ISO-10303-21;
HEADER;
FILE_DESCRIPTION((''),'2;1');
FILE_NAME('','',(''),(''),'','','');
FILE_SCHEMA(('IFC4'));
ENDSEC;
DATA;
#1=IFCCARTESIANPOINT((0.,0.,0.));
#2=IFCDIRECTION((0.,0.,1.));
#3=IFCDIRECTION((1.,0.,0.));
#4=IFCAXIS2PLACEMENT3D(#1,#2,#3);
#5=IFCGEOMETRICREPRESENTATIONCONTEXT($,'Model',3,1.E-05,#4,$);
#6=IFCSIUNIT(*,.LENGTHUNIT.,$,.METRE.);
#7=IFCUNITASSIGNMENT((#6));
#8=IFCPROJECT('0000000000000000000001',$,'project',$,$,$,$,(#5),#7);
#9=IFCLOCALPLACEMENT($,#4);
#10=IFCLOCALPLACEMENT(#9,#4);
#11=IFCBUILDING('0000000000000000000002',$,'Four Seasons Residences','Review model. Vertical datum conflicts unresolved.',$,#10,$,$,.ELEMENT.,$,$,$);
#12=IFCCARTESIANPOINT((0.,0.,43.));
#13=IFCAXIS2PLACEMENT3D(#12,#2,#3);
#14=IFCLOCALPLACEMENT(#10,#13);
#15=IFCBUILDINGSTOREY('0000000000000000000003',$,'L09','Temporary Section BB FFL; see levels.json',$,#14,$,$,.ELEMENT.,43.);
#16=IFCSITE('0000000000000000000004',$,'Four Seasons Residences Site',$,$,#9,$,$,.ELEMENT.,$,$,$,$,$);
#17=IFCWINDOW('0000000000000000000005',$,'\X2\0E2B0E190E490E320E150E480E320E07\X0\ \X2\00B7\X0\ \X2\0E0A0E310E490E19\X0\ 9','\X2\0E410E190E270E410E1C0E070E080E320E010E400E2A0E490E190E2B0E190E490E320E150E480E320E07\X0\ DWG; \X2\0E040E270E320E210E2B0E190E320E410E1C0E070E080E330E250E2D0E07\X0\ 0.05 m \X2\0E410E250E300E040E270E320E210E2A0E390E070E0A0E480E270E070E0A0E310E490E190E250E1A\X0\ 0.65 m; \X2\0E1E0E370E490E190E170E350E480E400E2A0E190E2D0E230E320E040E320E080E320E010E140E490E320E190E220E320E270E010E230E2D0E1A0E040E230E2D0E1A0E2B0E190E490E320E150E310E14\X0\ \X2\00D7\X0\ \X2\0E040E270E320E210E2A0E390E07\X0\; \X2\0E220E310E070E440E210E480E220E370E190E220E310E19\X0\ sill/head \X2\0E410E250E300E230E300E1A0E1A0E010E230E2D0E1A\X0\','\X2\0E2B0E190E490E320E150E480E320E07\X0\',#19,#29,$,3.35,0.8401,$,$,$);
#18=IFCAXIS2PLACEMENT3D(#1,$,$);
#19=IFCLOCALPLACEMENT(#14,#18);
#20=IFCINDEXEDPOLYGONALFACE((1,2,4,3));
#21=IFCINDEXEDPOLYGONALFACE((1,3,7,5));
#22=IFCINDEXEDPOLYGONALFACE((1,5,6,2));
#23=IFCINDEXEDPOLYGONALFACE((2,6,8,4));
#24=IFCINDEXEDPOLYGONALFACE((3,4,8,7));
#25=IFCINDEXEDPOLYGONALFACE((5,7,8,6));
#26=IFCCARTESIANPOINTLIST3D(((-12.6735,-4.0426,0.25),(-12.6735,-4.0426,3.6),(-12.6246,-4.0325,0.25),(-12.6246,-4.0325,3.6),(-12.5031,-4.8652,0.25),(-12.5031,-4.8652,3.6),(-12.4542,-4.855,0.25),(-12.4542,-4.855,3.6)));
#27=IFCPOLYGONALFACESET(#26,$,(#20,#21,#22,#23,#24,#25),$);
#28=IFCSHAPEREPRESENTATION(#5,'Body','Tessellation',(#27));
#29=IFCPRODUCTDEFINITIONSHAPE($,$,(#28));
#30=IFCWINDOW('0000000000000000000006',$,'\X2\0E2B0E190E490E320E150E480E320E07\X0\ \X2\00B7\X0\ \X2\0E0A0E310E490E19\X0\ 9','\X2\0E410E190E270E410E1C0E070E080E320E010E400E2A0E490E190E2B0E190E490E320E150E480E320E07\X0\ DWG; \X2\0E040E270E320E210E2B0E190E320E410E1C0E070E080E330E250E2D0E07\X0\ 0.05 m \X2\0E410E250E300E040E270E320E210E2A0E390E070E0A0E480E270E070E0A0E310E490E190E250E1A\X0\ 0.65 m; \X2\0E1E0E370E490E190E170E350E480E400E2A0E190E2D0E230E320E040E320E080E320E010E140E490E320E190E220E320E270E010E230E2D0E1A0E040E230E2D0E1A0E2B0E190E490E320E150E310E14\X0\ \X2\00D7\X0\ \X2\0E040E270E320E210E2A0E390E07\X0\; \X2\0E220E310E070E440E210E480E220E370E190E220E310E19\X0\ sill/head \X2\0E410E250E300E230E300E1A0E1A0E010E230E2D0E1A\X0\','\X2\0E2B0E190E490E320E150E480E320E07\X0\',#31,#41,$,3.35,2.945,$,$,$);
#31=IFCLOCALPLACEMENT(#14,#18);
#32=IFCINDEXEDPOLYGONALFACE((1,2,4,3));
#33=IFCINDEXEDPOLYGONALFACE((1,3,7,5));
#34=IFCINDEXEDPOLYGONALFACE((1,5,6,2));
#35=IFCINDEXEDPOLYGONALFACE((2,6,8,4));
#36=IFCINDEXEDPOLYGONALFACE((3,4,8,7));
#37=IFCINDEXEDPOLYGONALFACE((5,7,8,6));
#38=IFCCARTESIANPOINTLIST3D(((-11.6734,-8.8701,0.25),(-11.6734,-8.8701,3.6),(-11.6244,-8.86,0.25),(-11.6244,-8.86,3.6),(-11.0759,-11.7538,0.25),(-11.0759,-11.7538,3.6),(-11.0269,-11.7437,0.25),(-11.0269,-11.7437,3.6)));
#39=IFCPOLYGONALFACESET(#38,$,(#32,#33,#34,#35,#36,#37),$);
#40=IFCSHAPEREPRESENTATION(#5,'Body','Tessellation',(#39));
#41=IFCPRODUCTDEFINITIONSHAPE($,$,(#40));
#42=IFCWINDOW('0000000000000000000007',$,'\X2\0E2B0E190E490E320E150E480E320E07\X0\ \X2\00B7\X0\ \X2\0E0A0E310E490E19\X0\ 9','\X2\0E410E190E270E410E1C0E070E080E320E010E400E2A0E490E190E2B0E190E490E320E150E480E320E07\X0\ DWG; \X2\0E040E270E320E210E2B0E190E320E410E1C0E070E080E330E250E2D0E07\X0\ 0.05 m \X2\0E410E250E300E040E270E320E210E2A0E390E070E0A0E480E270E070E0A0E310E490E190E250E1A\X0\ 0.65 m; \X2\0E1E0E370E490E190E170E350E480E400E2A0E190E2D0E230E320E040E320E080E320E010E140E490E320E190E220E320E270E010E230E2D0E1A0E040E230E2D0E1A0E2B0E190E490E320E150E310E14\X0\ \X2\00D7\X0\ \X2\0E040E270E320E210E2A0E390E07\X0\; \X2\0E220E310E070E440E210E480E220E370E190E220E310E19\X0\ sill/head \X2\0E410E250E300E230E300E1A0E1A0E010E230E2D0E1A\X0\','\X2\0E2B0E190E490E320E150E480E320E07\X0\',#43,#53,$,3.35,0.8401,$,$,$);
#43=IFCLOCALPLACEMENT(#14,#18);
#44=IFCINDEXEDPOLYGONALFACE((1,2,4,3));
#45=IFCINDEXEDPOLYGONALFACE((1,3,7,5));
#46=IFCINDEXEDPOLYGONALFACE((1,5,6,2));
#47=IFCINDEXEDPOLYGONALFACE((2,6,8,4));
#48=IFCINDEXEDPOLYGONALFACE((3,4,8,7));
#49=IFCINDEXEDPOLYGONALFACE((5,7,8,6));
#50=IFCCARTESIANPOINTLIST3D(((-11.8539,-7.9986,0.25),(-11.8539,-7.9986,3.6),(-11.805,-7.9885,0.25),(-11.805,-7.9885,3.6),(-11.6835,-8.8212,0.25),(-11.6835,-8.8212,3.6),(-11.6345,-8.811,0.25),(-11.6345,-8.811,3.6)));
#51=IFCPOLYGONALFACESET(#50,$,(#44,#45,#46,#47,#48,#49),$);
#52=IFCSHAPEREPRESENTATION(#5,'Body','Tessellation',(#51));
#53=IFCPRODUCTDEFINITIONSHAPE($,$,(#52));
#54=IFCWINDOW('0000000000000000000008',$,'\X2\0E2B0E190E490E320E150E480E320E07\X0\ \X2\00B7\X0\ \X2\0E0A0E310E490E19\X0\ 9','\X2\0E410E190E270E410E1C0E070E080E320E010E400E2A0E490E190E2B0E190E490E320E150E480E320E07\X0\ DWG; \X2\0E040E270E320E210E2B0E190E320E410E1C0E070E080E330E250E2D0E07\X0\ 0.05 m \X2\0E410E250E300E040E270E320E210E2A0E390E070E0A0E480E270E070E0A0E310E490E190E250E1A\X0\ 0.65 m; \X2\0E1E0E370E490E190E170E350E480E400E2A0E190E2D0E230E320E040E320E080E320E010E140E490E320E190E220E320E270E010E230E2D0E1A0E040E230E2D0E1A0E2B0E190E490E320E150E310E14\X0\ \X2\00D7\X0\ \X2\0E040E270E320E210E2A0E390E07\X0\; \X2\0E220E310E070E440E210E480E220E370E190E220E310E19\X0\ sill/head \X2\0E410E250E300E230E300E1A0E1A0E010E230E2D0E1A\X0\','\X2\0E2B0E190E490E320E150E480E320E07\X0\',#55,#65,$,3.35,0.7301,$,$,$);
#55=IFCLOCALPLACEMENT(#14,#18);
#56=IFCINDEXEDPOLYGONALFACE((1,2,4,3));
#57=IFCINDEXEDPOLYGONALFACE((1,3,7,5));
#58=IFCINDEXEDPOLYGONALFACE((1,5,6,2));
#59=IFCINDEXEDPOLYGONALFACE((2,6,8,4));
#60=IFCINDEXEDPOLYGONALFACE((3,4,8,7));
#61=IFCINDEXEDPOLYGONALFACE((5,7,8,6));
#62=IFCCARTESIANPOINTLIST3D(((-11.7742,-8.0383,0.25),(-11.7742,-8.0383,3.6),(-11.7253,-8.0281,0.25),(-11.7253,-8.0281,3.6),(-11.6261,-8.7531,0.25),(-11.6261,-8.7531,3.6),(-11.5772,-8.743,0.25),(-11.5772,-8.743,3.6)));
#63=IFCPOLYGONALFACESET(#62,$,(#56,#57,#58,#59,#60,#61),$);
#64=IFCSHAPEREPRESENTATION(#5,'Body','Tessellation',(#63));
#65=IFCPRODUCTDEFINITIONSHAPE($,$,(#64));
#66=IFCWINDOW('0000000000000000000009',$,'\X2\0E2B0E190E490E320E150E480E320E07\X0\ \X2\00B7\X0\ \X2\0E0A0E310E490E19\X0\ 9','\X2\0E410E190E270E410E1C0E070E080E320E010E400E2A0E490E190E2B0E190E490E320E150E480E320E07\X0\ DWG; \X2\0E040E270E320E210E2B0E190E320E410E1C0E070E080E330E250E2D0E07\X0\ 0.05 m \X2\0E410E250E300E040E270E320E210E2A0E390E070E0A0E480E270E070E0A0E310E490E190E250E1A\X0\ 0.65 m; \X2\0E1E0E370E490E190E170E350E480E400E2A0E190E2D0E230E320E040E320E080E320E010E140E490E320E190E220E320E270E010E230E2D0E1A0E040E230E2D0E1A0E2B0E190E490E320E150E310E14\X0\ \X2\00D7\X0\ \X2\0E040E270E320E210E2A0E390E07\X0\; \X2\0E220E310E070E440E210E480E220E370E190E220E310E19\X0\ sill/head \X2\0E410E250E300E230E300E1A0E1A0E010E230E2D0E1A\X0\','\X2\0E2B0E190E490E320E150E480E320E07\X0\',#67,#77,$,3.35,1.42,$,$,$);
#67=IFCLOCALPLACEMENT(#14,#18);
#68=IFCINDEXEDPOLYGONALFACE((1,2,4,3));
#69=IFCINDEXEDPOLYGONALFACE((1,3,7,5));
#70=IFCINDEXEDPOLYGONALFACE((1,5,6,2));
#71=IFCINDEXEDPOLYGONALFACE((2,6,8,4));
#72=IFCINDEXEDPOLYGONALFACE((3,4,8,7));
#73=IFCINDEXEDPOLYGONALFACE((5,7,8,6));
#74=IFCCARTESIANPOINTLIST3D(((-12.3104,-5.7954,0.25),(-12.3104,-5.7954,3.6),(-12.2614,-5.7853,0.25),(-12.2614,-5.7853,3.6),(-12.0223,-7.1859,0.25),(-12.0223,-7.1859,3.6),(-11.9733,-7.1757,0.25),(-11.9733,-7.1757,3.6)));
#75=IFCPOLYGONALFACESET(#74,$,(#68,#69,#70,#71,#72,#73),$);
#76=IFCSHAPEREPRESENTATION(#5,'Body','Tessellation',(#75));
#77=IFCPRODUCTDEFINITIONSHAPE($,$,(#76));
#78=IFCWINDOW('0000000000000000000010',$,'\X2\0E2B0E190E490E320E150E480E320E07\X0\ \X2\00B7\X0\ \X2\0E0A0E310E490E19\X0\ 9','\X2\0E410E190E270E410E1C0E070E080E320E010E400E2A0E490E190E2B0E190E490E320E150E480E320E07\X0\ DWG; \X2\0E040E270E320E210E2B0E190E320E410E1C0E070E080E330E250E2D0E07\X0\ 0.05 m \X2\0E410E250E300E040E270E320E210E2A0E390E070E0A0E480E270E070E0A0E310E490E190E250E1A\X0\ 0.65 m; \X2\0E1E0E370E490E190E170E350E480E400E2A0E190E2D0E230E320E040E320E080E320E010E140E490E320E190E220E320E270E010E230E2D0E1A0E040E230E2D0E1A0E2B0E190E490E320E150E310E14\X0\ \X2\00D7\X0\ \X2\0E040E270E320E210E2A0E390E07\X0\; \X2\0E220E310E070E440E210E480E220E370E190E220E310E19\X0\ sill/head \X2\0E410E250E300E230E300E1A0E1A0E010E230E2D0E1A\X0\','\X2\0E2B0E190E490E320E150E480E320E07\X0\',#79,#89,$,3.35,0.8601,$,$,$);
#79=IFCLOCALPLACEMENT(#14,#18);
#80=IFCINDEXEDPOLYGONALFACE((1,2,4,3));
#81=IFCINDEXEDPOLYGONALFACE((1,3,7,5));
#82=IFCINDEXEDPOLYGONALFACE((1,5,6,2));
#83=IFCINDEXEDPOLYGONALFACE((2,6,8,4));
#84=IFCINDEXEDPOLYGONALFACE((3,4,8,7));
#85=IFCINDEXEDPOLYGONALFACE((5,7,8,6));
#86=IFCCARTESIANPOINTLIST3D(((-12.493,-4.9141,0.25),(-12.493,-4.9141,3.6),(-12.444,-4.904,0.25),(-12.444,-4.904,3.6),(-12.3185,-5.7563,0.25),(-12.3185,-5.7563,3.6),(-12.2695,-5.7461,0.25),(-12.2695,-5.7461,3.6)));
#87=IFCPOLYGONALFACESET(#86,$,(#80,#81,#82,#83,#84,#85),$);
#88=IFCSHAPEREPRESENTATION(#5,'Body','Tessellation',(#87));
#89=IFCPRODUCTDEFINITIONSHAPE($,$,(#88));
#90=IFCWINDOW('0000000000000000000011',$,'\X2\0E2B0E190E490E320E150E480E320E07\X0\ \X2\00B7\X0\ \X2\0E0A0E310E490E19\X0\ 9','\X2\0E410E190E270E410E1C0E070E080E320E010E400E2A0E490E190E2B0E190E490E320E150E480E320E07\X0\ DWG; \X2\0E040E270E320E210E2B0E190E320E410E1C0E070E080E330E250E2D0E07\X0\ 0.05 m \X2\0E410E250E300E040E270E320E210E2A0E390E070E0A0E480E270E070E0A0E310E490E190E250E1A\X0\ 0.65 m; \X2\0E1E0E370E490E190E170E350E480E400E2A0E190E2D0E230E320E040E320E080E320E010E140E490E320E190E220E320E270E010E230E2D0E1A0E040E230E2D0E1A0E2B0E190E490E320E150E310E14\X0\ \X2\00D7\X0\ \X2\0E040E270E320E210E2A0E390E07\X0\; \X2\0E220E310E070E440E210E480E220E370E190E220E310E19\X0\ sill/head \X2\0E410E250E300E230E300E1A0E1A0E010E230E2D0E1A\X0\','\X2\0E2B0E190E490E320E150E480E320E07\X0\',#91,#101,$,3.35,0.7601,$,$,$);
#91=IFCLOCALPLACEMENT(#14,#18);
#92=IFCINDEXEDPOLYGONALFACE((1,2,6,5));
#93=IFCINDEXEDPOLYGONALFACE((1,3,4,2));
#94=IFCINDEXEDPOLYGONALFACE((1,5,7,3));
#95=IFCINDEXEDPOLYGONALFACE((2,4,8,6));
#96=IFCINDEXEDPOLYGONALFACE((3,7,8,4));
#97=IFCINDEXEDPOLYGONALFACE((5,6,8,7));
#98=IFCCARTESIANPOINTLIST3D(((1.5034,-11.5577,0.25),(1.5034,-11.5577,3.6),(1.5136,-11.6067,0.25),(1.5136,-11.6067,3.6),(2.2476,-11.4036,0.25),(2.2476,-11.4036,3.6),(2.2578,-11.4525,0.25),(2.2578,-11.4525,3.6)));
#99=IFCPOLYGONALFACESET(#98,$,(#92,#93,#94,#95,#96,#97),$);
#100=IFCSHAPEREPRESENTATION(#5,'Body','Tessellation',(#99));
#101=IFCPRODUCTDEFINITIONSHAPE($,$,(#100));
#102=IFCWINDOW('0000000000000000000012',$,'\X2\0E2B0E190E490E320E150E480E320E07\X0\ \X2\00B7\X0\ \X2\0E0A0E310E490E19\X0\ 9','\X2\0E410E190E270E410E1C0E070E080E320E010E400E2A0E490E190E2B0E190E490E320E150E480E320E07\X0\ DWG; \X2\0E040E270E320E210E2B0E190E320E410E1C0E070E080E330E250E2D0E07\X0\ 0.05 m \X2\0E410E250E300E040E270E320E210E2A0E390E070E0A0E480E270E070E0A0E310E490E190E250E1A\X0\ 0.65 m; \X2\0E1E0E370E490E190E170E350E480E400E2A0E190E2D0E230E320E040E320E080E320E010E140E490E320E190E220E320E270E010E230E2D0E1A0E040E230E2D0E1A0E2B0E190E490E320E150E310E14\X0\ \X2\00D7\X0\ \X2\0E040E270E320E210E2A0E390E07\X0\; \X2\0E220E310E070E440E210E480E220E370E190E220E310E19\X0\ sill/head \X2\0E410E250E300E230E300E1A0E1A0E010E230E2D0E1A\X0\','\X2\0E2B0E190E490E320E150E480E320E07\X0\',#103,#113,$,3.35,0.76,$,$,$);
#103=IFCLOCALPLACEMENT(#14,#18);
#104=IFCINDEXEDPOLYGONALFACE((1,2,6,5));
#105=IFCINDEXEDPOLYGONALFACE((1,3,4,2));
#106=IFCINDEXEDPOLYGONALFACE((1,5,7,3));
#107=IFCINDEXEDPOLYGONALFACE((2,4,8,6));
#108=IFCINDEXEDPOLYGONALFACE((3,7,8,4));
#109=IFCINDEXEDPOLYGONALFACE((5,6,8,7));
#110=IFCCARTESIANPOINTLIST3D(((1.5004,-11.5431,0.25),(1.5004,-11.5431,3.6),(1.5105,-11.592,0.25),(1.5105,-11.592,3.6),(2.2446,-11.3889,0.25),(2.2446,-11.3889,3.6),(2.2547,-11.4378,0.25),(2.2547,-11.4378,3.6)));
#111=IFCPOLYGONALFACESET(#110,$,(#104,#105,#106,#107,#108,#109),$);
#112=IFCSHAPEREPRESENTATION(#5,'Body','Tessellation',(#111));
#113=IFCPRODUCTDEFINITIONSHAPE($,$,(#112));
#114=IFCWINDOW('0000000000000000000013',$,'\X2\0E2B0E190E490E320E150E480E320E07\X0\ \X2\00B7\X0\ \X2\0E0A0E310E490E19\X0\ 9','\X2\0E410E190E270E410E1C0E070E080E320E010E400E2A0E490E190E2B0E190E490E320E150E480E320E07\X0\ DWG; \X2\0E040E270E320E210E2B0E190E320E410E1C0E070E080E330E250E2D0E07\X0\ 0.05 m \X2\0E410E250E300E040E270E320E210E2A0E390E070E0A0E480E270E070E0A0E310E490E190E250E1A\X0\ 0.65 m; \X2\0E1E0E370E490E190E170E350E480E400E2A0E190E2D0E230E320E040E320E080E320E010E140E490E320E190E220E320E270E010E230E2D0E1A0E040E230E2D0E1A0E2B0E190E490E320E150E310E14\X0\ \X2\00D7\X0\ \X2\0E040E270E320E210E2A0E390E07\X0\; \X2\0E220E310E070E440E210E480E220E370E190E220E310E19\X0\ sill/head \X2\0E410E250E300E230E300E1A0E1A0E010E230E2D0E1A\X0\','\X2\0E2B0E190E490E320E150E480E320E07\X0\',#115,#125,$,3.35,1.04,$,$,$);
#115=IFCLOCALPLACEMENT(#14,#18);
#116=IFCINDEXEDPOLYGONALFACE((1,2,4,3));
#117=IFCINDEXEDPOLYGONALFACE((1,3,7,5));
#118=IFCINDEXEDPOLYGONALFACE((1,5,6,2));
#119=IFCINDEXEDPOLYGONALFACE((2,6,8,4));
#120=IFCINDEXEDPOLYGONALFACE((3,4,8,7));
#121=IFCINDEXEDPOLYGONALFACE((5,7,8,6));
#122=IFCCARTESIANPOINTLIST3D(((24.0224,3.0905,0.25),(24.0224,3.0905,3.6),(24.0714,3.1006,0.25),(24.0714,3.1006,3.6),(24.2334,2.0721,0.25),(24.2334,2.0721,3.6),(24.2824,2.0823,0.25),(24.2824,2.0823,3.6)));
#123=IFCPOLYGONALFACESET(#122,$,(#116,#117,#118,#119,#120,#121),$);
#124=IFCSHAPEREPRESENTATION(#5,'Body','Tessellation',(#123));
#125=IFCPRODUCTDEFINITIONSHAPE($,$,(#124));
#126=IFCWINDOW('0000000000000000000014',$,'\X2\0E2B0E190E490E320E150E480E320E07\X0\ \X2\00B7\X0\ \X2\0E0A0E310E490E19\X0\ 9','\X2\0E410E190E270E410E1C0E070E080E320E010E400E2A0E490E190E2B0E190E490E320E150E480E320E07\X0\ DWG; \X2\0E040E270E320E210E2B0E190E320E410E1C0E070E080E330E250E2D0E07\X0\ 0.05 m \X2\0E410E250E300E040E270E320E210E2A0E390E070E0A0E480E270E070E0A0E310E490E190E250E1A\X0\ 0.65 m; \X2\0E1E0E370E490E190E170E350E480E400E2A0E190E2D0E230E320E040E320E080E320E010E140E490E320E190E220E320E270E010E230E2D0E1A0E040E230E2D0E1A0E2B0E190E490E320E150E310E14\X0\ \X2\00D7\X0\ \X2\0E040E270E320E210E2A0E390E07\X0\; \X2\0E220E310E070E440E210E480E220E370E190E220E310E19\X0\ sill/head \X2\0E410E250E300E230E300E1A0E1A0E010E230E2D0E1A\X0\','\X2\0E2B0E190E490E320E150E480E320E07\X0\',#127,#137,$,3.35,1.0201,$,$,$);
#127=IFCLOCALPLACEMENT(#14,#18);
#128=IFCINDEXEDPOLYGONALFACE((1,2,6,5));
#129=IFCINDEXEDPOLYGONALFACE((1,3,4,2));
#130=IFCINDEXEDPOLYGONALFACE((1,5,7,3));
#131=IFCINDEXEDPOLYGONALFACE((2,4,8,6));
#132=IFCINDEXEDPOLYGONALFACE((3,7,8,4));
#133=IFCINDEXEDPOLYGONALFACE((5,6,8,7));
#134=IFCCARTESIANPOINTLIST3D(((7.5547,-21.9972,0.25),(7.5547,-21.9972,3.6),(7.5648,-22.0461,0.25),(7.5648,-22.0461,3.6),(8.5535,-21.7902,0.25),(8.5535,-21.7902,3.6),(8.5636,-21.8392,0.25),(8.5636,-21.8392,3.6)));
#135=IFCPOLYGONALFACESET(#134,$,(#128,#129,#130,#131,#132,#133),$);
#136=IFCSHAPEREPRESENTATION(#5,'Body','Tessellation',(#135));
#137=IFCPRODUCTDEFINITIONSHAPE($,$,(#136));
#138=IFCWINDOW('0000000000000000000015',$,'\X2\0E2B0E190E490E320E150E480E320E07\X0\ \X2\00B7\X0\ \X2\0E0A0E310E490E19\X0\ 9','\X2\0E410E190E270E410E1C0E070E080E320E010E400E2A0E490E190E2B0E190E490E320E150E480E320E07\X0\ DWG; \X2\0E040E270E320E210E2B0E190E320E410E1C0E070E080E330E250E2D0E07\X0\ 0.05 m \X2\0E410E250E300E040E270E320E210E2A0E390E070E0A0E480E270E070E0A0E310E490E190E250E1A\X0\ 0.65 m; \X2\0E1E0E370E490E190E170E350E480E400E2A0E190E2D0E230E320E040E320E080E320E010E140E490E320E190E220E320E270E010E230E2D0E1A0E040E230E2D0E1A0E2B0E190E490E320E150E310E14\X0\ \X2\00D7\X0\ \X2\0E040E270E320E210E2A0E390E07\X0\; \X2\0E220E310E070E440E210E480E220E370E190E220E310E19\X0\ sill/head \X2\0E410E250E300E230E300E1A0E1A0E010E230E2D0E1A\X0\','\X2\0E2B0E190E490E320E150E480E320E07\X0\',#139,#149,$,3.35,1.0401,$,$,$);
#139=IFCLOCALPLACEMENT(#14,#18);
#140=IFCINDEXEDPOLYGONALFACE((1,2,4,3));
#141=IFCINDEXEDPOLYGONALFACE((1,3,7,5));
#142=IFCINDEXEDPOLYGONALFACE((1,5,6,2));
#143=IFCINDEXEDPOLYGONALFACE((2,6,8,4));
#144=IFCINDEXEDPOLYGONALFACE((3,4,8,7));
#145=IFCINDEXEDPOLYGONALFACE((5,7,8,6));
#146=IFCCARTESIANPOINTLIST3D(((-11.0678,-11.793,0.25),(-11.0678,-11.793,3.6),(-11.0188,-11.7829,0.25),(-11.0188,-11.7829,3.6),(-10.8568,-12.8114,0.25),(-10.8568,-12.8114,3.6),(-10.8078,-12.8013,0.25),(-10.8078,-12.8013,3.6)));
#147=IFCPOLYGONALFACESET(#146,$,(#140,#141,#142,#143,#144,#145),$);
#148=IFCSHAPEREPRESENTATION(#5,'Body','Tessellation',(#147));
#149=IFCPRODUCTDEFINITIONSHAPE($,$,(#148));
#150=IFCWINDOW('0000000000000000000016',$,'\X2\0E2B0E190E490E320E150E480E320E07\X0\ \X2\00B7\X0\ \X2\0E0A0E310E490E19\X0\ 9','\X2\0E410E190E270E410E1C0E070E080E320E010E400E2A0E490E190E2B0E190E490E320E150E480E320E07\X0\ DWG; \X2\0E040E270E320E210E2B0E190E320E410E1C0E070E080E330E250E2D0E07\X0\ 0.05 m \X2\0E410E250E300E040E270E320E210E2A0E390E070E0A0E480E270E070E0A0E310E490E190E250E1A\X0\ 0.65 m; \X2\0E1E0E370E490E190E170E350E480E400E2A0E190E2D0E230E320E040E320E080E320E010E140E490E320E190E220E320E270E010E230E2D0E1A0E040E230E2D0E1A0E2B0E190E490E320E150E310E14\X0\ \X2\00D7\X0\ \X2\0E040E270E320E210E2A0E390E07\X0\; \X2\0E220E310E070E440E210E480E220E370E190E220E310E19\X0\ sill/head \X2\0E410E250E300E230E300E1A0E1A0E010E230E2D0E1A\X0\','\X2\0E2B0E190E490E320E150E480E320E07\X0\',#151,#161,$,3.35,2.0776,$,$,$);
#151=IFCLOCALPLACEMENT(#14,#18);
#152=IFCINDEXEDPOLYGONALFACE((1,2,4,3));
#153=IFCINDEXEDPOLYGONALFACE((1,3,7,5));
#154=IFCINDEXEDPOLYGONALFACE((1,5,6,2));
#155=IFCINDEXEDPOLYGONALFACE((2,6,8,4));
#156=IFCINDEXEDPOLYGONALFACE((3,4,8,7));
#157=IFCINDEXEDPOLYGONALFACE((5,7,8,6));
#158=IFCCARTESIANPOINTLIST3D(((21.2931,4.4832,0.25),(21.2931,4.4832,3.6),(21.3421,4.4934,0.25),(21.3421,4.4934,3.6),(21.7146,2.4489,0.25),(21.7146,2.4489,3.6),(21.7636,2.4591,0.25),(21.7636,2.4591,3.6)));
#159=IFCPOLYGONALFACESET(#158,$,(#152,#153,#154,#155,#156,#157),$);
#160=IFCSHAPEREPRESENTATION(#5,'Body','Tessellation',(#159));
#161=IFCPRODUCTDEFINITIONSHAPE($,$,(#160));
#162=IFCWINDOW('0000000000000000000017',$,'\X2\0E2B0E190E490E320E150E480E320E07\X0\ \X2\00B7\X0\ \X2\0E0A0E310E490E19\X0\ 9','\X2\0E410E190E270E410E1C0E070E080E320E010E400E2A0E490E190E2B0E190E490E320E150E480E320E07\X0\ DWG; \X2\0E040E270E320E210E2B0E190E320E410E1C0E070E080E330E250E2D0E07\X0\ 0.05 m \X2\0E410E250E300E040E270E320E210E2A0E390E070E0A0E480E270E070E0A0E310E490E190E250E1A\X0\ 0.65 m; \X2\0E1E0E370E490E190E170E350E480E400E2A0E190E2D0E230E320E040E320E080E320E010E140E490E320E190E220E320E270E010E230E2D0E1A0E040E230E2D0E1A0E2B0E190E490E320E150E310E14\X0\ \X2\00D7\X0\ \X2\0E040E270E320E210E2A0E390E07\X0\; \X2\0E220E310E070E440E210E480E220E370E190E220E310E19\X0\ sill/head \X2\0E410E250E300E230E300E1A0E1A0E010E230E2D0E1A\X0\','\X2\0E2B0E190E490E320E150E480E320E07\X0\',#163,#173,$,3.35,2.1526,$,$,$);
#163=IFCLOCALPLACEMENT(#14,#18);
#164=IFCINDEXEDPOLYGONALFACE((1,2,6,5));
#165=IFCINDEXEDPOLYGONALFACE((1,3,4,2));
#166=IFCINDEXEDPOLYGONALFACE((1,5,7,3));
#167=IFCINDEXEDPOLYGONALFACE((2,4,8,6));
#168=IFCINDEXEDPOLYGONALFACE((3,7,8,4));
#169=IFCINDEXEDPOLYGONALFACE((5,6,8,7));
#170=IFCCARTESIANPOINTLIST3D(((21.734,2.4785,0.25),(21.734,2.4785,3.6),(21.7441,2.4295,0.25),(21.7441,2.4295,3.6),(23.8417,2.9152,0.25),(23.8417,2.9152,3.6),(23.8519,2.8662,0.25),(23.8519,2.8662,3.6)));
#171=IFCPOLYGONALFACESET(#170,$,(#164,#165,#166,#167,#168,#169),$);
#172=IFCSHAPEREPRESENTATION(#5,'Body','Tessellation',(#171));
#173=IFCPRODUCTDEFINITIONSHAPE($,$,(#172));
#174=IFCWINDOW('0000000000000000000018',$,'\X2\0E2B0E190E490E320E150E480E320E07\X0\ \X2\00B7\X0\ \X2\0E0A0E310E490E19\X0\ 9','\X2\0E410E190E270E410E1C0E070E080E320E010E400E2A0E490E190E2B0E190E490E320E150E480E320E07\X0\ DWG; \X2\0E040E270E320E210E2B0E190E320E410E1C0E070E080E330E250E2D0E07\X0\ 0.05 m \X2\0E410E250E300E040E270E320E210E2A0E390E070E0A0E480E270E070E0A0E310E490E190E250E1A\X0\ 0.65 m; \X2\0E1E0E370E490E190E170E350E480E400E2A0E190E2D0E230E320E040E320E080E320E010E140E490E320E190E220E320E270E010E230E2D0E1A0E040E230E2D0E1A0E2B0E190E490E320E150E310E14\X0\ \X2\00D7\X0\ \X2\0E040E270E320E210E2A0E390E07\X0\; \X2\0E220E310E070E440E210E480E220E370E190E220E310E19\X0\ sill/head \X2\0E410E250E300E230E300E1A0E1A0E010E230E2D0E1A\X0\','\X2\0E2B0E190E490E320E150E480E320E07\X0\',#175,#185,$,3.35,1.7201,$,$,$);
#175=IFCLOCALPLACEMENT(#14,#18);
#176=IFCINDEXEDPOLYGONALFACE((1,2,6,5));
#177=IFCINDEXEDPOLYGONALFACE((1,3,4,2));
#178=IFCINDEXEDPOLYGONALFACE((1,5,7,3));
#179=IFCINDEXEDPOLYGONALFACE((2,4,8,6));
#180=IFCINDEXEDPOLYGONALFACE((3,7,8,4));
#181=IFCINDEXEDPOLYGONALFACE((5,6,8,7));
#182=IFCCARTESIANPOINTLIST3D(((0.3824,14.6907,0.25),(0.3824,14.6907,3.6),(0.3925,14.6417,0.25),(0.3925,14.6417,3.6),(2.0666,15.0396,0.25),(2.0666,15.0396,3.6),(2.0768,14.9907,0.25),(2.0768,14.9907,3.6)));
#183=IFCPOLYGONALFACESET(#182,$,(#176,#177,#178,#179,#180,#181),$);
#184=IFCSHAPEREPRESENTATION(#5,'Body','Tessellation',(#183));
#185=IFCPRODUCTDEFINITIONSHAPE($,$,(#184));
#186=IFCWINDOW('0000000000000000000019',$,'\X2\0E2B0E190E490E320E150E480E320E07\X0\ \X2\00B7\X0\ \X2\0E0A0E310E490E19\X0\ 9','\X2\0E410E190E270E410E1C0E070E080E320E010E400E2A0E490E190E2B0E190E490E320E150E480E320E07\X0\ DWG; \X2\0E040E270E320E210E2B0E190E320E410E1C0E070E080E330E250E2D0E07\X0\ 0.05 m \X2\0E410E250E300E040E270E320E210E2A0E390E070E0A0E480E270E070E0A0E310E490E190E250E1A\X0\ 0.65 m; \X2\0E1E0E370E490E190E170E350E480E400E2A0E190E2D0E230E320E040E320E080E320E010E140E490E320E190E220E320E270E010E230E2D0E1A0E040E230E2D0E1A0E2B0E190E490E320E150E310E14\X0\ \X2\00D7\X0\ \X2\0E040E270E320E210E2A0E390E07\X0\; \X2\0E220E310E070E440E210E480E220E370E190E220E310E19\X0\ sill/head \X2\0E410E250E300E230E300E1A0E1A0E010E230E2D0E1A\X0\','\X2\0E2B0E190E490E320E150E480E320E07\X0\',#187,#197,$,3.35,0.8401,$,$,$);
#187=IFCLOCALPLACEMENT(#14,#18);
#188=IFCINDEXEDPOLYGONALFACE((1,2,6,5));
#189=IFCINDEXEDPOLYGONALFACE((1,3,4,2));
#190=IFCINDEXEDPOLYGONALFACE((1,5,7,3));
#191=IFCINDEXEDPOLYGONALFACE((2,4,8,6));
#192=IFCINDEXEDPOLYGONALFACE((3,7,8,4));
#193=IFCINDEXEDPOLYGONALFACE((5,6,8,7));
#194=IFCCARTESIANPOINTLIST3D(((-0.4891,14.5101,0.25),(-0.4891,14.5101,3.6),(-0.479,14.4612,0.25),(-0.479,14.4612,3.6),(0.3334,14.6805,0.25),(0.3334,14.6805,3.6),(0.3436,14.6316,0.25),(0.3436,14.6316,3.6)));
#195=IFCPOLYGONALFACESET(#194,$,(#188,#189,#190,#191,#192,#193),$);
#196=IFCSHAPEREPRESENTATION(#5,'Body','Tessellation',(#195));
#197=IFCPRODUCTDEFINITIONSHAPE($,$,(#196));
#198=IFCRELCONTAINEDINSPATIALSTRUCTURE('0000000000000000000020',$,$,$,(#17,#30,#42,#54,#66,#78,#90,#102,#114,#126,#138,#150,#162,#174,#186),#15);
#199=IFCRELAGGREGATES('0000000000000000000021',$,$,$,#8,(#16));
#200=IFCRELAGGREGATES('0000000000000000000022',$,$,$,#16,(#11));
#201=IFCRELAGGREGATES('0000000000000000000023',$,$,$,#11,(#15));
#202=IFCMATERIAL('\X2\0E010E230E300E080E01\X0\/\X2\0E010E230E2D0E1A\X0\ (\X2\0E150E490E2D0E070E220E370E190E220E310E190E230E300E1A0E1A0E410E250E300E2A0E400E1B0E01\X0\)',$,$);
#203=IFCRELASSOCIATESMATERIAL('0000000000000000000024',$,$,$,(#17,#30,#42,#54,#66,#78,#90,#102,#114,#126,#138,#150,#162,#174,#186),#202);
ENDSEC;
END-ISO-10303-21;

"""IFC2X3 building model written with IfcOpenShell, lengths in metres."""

from ifc_helpers import new_model, si_unit, frame, origin_with_axes, place, context, project, spatial, polyline, outline, extrude, material, element, save


model = new_model("IFC2X3")

# Units and contexts
model_context = context("Model", 3, precision=1e-05, world=origin_with_axes())
ifc_project = project(units=[si_unit("LENGTHUNIT", "METRE")], contexts=[model_context])

# Site, building, storey
site_placement = place(None, origin_with_axes())
site = spatial("IfcSite", under=ifc_project, at=site_placement, Name="Four Seasons Residences Site", CompositionType="ELEMENT")
building_placement = place(site_placement, origin_with_axes())
building = spatial("IfcBuilding", under=site, at=building_placement, Name="Four Seasons Residences", Description="Review model. Vertical datum conflicts unresolved.", CompositionType="ELEMENT")
storey_placement = place(building_placement, frame((0.0, 0.0, 43.0), z_axis=(0.0, 0.0, 1.0), x_axis=(1.0, 0.0, 0.0)))
storey = spatial("IfcBuildingStorey", under=building, at=storey_placement, Name="L09", Description="Temporary Section BB FFL; see levels.json", CompositionType="ELEMENT", Elevation=43.0)

# Windows
ifc_material = material(Name="กระจก/กรอบ (ต้องยืนยันระบบและสเปก)")
window_1_placement = place(storey_placement, origin_with_axes())
element("IfcWindow", 1, at=window_1_placement, inside=storey, material=ifc_material, Name="หน้าต่าง · ชั้น 9", Description="แนวแผงจากเส้นหน้าต่าง DWG; ความหนาแผงจำลอง 0.05 m และความสูงช่วงชั้นลบ 0.65 m; พื้นที่เสนอราคาจากด้านยาวกรอบครอบหน้าตัด × ความสูง; ยังไม่ยืนยัน sill/head และระบบกรอบ", ObjectType="หน้าต่าง", OverallHeight=3.35, OverallWidth=0.8401, context=model_context, shape_type="SweptSolid", body=[
    extrude(outline(polyline([(-12.6735, -4.0426), (-12.6246, -4.0325), (-12.4542, -4.855), (-12.5031, -4.8652), (-12.6735, -4.0426)])), frame((0.0, 0.0, 0.25), z_axis=(0.0, 0.0, 1.0), x_axis=(1.0, 0.0, 0.0)), (0.0, 0.0, 1.0), 3.35),
])
window_2_placement = place(storey_placement, origin_with_axes())
element("IfcWindow", 2, at=window_2_placement, inside=storey, material=ifc_material, Name="หน้าต่าง · ชั้น 9", Description="แนวแผงจากเส้นหน้าต่าง DWG; ความหนาแผงจำลอง 0.05 m และความสูงช่วงชั้นลบ 0.65 m; พื้นที่เสนอราคาจากด้านยาวกรอบครอบหน้าตัด × ความสูง; ยังไม่ยืนยัน sill/head และระบบกรอบ", ObjectType="หน้าต่าง", OverallHeight=3.35, OverallWidth=2.945, context=model_context, shape_type="SweptSolid", body=[
    extrude(outline(polyline([(-11.6734, -8.8701), (-11.6244, -8.86), (-11.0269, -11.7437), (-11.0759, -11.7538), (-11.6734, -8.8701)])), frame((0.0, 0.0, 0.25), z_axis=(0.0, 0.0, 1.0), x_axis=(1.0, 0.0, 0.0)), (0.0, 0.0, 1.0), 3.35),
])
window_3_placement = place(storey_placement, origin_with_axes())
element("IfcWindow", 3, at=window_3_placement, inside=storey, material=ifc_material, Name="หน้าต่าง · ชั้น 9", Description="แนวแผงจากเส้นหน้าต่าง DWG; ความหนาแผงจำลอง 0.05 m และความสูงช่วงชั้นลบ 0.65 m; พื้นที่เสนอราคาจากด้านยาวกรอบครอบหน้าตัด × ความสูง; ยังไม่ยืนยัน sill/head และระบบกรอบ", ObjectType="หน้าต่าง", OverallHeight=3.35, OverallWidth=0.8401, context=model_context, shape_type="SweptSolid", body=[
    extrude(outline(polyline([(-11.8539, -7.9986), (-11.805, -7.9885), (-11.6345, -8.811), (-11.6835, -8.8212), (-11.8539, -7.9986)])), frame((0.0, 0.0, 0.25), z_axis=(0.0, 0.0, 1.0), x_axis=(1.0, 0.0, 0.0)), (0.0, 0.0, 1.0), 3.35),
])
window_4_placement = place(storey_placement, origin_with_axes())
element("IfcWindow", 4, at=window_4_placement, inside=storey, material=ifc_material, Name="หน้าต่าง · ชั้น 9", Description="แนวแผงจากเส้นหน้าต่าง DWG; ความหนาแผงจำลอง 0.05 m และความสูงช่วงชั้นลบ 0.65 m; พื้นที่เสนอราคาจากด้านยาวกรอบครอบหน้าตัด × ความสูง; ยังไม่ยืนยัน sill/head และระบบกรอบ", ObjectType="หน้าต่าง", OverallHeight=3.35, OverallWidth=0.7301, context=model_context, shape_type="SweptSolid", body=[
    extrude(outline(polyline([(-11.7742, -8.0383), (-11.7253, -8.0281), (-11.5772, -8.743), (-11.6261, -8.7531), (-11.7742, -8.0383)])), frame((0.0, 0.0, 0.25), z_axis=(0.0, 0.0, 1.0), x_axis=(1.0, 0.0, 0.0)), (0.0, 0.0, 1.0), 3.35),
])
window_5_placement = place(storey_placement, origin_with_axes())
element("IfcWindow", 5, at=window_5_placement, inside=storey, material=ifc_material, Name="หน้าต่าง · ชั้น 9", Description="แนวแผงจากเส้นหน้าต่าง DWG; ความหนาแผงจำลอง 0.05 m และความสูงช่วงชั้นลบ 0.65 m; พื้นที่เสนอราคาจากด้านยาวกรอบครอบหน้าตัด × ความสูง; ยังไม่ยืนยัน sill/head และระบบกรอบ", ObjectType="หน้าต่าง", OverallHeight=3.35, OverallWidth=1.42, context=model_context, shape_type="SweptSolid", body=[
    extrude(outline(polyline([(-12.3104, -5.7954), (-12.2614, -5.7853), (-11.9733, -7.1757), (-12.0223, -7.1859), (-12.3104, -5.7954)])), frame((0.0, 0.0, 0.25), z_axis=(0.0, 0.0, 1.0), x_axis=(1.0, 0.0, 0.0)), (0.0, 0.0, 1.0), 3.35),
])
window_6_placement = place(storey_placement, origin_with_axes())
element("IfcWindow", 6, at=window_6_placement, inside=storey, material=ifc_material, Name="หน้าต่าง · ชั้น 9", Description="แนวแผงจากเส้นหน้าต่าง DWG; ความหนาแผงจำลอง 0.05 m และความสูงช่วงชั้นลบ 0.65 m; พื้นที่เสนอราคาจากด้านยาวกรอบครอบหน้าตัด × ความสูง; ยังไม่ยืนยัน sill/head และระบบกรอบ", ObjectType="หน้าต่าง", OverallHeight=3.35, OverallWidth=0.8601, context=model_context, shape_type="SweptSolid", body=[
    extrude(outline(polyline([(-12.493, -4.9141), (-12.444, -4.904), (-12.2695, -5.7461), (-12.3185, -5.7563), (-12.493, -4.9141)])), frame((0.0, 0.0, 0.25), z_axis=(0.0, 0.0, 1.0), x_axis=(1.0, 0.0, 0.0)), (0.0, 0.0, 1.0), 3.35),
])
window_7_placement = place(storey_placement, origin_with_axes())
element("IfcWindow", 7, at=window_7_placement, inside=storey, material=ifc_material, Name="หน้าต่าง · ชั้น 9", Description="แนวแผงจากเส้นหน้าต่าง DWG; ความหนาแผงจำลอง 0.05 m และความสูงช่วงชั้นลบ 0.65 m; พื้นที่เสนอราคาจากด้านยาวกรอบครอบหน้าตัด × ความสูง; ยังไม่ยืนยัน sill/head และระบบกรอบ", ObjectType="หน้าต่าง", OverallHeight=3.35, OverallWidth=0.7601, context=model_context, shape_type="SweptSolid", body=[
    extrude(outline(polyline([(2.2476, -11.4036), (2.2578, -11.4525), (1.5136, -11.6067), (1.5034, -11.5577), (2.2476, -11.4036)])), frame((0.0, 0.0, 0.25), z_axis=(0.0, 0.0, 1.0), x_axis=(1.0, 0.0, 0.0)), (0.0, 0.0, 1.0), 3.35),
])
window_8_placement = place(storey_placement, origin_with_axes())
element("IfcWindow", 8, at=window_8_placement, inside=storey, material=ifc_material, Name="หน้าต่าง · ชั้น 9", Description="แนวแผงจากเส้นหน้าต่าง DWG; ความหนาแผงจำลอง 0.05 m และความสูงช่วงชั้นลบ 0.65 m; พื้นที่เสนอราคาจากด้านยาวกรอบครอบหน้าตัด × ความสูง; ยังไม่ยืนยัน sill/head และระบบกรอบ", ObjectType="หน้าต่าง", OverallHeight=3.35, OverallWidth=0.76, context=model_context, shape_type="SweptSolid", body=[
    extrude(outline(polyline([(2.2446, -11.3889), (2.2547, -11.4378), (1.5105, -11.592), (1.5004, -11.5431), (2.2446, -11.3889)])), frame((0.0, 0.0, 0.25), z_axis=(0.0, 0.0, 1.0), x_axis=(1.0, 0.0, 0.0)), (0.0, 0.0, 1.0), 3.35),
])
window_9_placement = place(storey_placement, origin_with_axes())
element("IfcWindow", 9, at=window_9_placement, inside=storey, material=ifc_material, Name="หน้าต่าง · ชั้น 9", Description="แนวแผงจากเส้นหน้าต่าง DWG; ความหนาแผงจำลอง 0.05 m และความสูงช่วงชั้นลบ 0.65 m; พื้นที่เสนอราคาจากด้านยาวกรอบครอบหน้าตัด × ความสูง; ยังไม่ยืนยัน sill/head และระบบกรอบ", ObjectType="หน้าต่าง", OverallHeight=3.35, OverallWidth=1.04, context=model_context, shape_type="SweptSolid", body=[
    extrude(outline(polyline([(24.0224, 3.0905), (24.0714, 3.1006), (24.2824, 2.0823), (24.2334, 2.0721), (24.0224, 3.0905)])), frame((0.0, 0.0, 0.25), z_axis=(0.0, 0.0, 1.0), x_axis=(1.0, 0.0, 0.0)), (0.0, 0.0, 1.0), 3.35),
])
window_10_placement = place(storey_placement, origin_with_axes())
element("IfcWindow", 10, at=window_10_placement, inside=storey, material=ifc_material, Name="หน้าต่าง · ชั้น 9", Description="แนวแผงจากเส้นหน้าต่าง DWG; ความหนาแผงจำลอง 0.05 m และความสูงช่วงชั้นลบ 0.65 m; พื้นที่เสนอราคาจากด้านยาวกรอบครอบหน้าตัด × ความสูง; ยังไม่ยืนยัน sill/head และระบบกรอบ", ObjectType="หน้าต่าง", OverallHeight=3.35, OverallWidth=1.0201, context=model_context, shape_type="SweptSolid", body=[
    extrude(outline(polyline([(7.5648, -22.0461), (7.5547, -21.9972), (8.5535, -21.7902), (8.5636, -21.8392), (7.5648, -22.0461)])), frame((0.0, 0.0, 0.25), z_axis=(0.0, 0.0, 1.0), x_axis=(1.0, 0.0, 0.0)), (0.0, 0.0, 1.0), 3.35),
])
window_11_placement = place(storey_placement, origin_with_axes())
element("IfcWindow", 11, at=window_11_placement, inside=storey, material=ifc_material, Name="หน้าต่าง · ชั้น 9", Description="แนวแผงจากเส้นหน้าต่าง DWG; ความหนาแผงจำลอง 0.05 m และความสูงช่วงชั้นลบ 0.65 m; พื้นที่เสนอราคาจากด้านยาวกรอบครอบหน้าตัด × ความสูง; ยังไม่ยืนยัน sill/head และระบบกรอบ", ObjectType="หน้าต่าง", OverallHeight=3.35, OverallWidth=1.0401, context=model_context, shape_type="SweptSolid", body=[
    extrude(outline(polyline([(-10.8078, -12.8013), (-10.8568, -12.8114), (-11.0678, -11.793), (-11.0188, -11.7829), (-10.8078, -12.8013)])), frame((0.0, 0.0, 0.25), z_axis=(0.0, 0.0, 1.0), x_axis=(1.0, 0.0, 0.0)), (0.0, 0.0, 1.0), 3.35),
])
window_12_placement = place(storey_placement, origin_with_axes())
element("IfcWindow", 12, at=window_12_placement, inside=storey, material=ifc_material, Name="หน้าต่าง · ชั้น 9", Description="แนวแผงจากเส้นหน้าต่าง DWG; ความหนาแผงจำลอง 0.05 m และความสูงช่วงชั้นลบ 0.65 m; พื้นที่เสนอราคาจากด้านยาวกรอบครอบหน้าตัด × ความสูง; ยังไม่ยืนยัน sill/head และระบบกรอบ", ObjectType="หน้าต่าง", OverallHeight=3.35, OverallWidth=2.0776, context=model_context, shape_type="SweptSolid", body=[
    extrude(outline(polyline([(21.7636, 2.4591), (21.7146, 2.4489), (21.2931, 4.4832), (21.3421, 4.4934), (21.7636, 2.4591)])), frame((0.0, 0.0, 0.25), z_axis=(0.0, 0.0, 1.0), x_axis=(1.0, 0.0, 0.0)), (0.0, 0.0, 1.0), 3.35),
])
window_13_placement = place(storey_placement, origin_with_axes())
element("IfcWindow", 13, at=window_13_placement, inside=storey, material=ifc_material, Name="หน้าต่าง · ชั้น 9", Description="แนวแผงจากเส้นหน้าต่าง DWG; ความหนาแผงจำลอง 0.05 m และความสูงช่วงชั้นลบ 0.65 m; พื้นที่เสนอราคาจากด้านยาวกรอบครอบหน้าตัด × ความสูง; ยังไม่ยืนยัน sill/head และระบบกรอบ", ObjectType="หน้าต่าง", OverallHeight=3.35, OverallWidth=2.1526, context=model_context, shape_type="SweptSolid", body=[
    extrude(outline(polyline([(21.7441, 2.4295), (21.734, 2.4785), (23.8417, 2.9152), (23.8519, 2.8662), (21.7441, 2.4295)])), frame((0.0, 0.0, 0.25), z_axis=(0.0, 0.0, 1.0), x_axis=(1.0, 0.0, 0.0)), (0.0, 0.0, 1.0), 3.35),
])
window_14_placement = place(storey_placement, origin_with_axes())
element("IfcWindow", 14, at=window_14_placement, inside=storey, material=ifc_material, Name="หน้าต่าง · ชั้น 9", Description="แนวแผงจากเส้นหน้าต่าง DWG; ความหนาแผงจำลอง 0.05 m และความสูงช่วงชั้นลบ 0.65 m; พื้นที่เสนอราคาจากด้านยาวกรอบครอบหน้าตัด × ความสูง; ยังไม่ยืนยัน sill/head และระบบกรอบ", ObjectType="หน้าต่าง", OverallHeight=3.35, OverallWidth=1.7201, context=model_context, shape_type="SweptSolid", body=[
    extrude(outline(polyline([(0.3925, 14.6417), (0.3824, 14.6907), (2.0666, 15.0396), (2.0768, 14.9907), (0.3925, 14.6417)])), frame((0.0, 0.0, 0.25), z_axis=(0.0, 0.0, 1.0), x_axis=(1.0, 0.0, 0.0)), (0.0, 0.0, 1.0), 3.35),
])
window_15_placement = place(storey_placement, origin_with_axes())
element("IfcWindow", 15, at=window_15_placement, inside=storey, material=ifc_material, Name="หน้าต่าง · ชั้น 9", Description="แนวแผงจากเส้นหน้าต่าง DWG; ความหนาแผงจำลอง 0.05 m และความสูงช่วงชั้นลบ 0.65 m; พื้นที่เสนอราคาจากด้านยาวกรอบครอบหน้าตัด × ความสูง; ยังไม่ยืนยัน sill/head และระบบกรอบ", ObjectType="หน้าต่าง", OverallHeight=3.35, OverallWidth=0.8401, context=model_context, shape_type="SweptSolid", body=[
    extrude(outline(polyline([(-0.479, 14.4612), (-0.4891, 14.5101), (0.3334, 14.6805), (0.3436, 14.6316), (-0.479, 14.4612)])), frame((0.0, 0.0, 0.25), z_axis=(0.0, 0.0, 1.0), x_axis=(1.0, 0.0, 0.0)), (0.0, 0.0, 1.0), 3.35),
])

save(model, "model.ifc")
